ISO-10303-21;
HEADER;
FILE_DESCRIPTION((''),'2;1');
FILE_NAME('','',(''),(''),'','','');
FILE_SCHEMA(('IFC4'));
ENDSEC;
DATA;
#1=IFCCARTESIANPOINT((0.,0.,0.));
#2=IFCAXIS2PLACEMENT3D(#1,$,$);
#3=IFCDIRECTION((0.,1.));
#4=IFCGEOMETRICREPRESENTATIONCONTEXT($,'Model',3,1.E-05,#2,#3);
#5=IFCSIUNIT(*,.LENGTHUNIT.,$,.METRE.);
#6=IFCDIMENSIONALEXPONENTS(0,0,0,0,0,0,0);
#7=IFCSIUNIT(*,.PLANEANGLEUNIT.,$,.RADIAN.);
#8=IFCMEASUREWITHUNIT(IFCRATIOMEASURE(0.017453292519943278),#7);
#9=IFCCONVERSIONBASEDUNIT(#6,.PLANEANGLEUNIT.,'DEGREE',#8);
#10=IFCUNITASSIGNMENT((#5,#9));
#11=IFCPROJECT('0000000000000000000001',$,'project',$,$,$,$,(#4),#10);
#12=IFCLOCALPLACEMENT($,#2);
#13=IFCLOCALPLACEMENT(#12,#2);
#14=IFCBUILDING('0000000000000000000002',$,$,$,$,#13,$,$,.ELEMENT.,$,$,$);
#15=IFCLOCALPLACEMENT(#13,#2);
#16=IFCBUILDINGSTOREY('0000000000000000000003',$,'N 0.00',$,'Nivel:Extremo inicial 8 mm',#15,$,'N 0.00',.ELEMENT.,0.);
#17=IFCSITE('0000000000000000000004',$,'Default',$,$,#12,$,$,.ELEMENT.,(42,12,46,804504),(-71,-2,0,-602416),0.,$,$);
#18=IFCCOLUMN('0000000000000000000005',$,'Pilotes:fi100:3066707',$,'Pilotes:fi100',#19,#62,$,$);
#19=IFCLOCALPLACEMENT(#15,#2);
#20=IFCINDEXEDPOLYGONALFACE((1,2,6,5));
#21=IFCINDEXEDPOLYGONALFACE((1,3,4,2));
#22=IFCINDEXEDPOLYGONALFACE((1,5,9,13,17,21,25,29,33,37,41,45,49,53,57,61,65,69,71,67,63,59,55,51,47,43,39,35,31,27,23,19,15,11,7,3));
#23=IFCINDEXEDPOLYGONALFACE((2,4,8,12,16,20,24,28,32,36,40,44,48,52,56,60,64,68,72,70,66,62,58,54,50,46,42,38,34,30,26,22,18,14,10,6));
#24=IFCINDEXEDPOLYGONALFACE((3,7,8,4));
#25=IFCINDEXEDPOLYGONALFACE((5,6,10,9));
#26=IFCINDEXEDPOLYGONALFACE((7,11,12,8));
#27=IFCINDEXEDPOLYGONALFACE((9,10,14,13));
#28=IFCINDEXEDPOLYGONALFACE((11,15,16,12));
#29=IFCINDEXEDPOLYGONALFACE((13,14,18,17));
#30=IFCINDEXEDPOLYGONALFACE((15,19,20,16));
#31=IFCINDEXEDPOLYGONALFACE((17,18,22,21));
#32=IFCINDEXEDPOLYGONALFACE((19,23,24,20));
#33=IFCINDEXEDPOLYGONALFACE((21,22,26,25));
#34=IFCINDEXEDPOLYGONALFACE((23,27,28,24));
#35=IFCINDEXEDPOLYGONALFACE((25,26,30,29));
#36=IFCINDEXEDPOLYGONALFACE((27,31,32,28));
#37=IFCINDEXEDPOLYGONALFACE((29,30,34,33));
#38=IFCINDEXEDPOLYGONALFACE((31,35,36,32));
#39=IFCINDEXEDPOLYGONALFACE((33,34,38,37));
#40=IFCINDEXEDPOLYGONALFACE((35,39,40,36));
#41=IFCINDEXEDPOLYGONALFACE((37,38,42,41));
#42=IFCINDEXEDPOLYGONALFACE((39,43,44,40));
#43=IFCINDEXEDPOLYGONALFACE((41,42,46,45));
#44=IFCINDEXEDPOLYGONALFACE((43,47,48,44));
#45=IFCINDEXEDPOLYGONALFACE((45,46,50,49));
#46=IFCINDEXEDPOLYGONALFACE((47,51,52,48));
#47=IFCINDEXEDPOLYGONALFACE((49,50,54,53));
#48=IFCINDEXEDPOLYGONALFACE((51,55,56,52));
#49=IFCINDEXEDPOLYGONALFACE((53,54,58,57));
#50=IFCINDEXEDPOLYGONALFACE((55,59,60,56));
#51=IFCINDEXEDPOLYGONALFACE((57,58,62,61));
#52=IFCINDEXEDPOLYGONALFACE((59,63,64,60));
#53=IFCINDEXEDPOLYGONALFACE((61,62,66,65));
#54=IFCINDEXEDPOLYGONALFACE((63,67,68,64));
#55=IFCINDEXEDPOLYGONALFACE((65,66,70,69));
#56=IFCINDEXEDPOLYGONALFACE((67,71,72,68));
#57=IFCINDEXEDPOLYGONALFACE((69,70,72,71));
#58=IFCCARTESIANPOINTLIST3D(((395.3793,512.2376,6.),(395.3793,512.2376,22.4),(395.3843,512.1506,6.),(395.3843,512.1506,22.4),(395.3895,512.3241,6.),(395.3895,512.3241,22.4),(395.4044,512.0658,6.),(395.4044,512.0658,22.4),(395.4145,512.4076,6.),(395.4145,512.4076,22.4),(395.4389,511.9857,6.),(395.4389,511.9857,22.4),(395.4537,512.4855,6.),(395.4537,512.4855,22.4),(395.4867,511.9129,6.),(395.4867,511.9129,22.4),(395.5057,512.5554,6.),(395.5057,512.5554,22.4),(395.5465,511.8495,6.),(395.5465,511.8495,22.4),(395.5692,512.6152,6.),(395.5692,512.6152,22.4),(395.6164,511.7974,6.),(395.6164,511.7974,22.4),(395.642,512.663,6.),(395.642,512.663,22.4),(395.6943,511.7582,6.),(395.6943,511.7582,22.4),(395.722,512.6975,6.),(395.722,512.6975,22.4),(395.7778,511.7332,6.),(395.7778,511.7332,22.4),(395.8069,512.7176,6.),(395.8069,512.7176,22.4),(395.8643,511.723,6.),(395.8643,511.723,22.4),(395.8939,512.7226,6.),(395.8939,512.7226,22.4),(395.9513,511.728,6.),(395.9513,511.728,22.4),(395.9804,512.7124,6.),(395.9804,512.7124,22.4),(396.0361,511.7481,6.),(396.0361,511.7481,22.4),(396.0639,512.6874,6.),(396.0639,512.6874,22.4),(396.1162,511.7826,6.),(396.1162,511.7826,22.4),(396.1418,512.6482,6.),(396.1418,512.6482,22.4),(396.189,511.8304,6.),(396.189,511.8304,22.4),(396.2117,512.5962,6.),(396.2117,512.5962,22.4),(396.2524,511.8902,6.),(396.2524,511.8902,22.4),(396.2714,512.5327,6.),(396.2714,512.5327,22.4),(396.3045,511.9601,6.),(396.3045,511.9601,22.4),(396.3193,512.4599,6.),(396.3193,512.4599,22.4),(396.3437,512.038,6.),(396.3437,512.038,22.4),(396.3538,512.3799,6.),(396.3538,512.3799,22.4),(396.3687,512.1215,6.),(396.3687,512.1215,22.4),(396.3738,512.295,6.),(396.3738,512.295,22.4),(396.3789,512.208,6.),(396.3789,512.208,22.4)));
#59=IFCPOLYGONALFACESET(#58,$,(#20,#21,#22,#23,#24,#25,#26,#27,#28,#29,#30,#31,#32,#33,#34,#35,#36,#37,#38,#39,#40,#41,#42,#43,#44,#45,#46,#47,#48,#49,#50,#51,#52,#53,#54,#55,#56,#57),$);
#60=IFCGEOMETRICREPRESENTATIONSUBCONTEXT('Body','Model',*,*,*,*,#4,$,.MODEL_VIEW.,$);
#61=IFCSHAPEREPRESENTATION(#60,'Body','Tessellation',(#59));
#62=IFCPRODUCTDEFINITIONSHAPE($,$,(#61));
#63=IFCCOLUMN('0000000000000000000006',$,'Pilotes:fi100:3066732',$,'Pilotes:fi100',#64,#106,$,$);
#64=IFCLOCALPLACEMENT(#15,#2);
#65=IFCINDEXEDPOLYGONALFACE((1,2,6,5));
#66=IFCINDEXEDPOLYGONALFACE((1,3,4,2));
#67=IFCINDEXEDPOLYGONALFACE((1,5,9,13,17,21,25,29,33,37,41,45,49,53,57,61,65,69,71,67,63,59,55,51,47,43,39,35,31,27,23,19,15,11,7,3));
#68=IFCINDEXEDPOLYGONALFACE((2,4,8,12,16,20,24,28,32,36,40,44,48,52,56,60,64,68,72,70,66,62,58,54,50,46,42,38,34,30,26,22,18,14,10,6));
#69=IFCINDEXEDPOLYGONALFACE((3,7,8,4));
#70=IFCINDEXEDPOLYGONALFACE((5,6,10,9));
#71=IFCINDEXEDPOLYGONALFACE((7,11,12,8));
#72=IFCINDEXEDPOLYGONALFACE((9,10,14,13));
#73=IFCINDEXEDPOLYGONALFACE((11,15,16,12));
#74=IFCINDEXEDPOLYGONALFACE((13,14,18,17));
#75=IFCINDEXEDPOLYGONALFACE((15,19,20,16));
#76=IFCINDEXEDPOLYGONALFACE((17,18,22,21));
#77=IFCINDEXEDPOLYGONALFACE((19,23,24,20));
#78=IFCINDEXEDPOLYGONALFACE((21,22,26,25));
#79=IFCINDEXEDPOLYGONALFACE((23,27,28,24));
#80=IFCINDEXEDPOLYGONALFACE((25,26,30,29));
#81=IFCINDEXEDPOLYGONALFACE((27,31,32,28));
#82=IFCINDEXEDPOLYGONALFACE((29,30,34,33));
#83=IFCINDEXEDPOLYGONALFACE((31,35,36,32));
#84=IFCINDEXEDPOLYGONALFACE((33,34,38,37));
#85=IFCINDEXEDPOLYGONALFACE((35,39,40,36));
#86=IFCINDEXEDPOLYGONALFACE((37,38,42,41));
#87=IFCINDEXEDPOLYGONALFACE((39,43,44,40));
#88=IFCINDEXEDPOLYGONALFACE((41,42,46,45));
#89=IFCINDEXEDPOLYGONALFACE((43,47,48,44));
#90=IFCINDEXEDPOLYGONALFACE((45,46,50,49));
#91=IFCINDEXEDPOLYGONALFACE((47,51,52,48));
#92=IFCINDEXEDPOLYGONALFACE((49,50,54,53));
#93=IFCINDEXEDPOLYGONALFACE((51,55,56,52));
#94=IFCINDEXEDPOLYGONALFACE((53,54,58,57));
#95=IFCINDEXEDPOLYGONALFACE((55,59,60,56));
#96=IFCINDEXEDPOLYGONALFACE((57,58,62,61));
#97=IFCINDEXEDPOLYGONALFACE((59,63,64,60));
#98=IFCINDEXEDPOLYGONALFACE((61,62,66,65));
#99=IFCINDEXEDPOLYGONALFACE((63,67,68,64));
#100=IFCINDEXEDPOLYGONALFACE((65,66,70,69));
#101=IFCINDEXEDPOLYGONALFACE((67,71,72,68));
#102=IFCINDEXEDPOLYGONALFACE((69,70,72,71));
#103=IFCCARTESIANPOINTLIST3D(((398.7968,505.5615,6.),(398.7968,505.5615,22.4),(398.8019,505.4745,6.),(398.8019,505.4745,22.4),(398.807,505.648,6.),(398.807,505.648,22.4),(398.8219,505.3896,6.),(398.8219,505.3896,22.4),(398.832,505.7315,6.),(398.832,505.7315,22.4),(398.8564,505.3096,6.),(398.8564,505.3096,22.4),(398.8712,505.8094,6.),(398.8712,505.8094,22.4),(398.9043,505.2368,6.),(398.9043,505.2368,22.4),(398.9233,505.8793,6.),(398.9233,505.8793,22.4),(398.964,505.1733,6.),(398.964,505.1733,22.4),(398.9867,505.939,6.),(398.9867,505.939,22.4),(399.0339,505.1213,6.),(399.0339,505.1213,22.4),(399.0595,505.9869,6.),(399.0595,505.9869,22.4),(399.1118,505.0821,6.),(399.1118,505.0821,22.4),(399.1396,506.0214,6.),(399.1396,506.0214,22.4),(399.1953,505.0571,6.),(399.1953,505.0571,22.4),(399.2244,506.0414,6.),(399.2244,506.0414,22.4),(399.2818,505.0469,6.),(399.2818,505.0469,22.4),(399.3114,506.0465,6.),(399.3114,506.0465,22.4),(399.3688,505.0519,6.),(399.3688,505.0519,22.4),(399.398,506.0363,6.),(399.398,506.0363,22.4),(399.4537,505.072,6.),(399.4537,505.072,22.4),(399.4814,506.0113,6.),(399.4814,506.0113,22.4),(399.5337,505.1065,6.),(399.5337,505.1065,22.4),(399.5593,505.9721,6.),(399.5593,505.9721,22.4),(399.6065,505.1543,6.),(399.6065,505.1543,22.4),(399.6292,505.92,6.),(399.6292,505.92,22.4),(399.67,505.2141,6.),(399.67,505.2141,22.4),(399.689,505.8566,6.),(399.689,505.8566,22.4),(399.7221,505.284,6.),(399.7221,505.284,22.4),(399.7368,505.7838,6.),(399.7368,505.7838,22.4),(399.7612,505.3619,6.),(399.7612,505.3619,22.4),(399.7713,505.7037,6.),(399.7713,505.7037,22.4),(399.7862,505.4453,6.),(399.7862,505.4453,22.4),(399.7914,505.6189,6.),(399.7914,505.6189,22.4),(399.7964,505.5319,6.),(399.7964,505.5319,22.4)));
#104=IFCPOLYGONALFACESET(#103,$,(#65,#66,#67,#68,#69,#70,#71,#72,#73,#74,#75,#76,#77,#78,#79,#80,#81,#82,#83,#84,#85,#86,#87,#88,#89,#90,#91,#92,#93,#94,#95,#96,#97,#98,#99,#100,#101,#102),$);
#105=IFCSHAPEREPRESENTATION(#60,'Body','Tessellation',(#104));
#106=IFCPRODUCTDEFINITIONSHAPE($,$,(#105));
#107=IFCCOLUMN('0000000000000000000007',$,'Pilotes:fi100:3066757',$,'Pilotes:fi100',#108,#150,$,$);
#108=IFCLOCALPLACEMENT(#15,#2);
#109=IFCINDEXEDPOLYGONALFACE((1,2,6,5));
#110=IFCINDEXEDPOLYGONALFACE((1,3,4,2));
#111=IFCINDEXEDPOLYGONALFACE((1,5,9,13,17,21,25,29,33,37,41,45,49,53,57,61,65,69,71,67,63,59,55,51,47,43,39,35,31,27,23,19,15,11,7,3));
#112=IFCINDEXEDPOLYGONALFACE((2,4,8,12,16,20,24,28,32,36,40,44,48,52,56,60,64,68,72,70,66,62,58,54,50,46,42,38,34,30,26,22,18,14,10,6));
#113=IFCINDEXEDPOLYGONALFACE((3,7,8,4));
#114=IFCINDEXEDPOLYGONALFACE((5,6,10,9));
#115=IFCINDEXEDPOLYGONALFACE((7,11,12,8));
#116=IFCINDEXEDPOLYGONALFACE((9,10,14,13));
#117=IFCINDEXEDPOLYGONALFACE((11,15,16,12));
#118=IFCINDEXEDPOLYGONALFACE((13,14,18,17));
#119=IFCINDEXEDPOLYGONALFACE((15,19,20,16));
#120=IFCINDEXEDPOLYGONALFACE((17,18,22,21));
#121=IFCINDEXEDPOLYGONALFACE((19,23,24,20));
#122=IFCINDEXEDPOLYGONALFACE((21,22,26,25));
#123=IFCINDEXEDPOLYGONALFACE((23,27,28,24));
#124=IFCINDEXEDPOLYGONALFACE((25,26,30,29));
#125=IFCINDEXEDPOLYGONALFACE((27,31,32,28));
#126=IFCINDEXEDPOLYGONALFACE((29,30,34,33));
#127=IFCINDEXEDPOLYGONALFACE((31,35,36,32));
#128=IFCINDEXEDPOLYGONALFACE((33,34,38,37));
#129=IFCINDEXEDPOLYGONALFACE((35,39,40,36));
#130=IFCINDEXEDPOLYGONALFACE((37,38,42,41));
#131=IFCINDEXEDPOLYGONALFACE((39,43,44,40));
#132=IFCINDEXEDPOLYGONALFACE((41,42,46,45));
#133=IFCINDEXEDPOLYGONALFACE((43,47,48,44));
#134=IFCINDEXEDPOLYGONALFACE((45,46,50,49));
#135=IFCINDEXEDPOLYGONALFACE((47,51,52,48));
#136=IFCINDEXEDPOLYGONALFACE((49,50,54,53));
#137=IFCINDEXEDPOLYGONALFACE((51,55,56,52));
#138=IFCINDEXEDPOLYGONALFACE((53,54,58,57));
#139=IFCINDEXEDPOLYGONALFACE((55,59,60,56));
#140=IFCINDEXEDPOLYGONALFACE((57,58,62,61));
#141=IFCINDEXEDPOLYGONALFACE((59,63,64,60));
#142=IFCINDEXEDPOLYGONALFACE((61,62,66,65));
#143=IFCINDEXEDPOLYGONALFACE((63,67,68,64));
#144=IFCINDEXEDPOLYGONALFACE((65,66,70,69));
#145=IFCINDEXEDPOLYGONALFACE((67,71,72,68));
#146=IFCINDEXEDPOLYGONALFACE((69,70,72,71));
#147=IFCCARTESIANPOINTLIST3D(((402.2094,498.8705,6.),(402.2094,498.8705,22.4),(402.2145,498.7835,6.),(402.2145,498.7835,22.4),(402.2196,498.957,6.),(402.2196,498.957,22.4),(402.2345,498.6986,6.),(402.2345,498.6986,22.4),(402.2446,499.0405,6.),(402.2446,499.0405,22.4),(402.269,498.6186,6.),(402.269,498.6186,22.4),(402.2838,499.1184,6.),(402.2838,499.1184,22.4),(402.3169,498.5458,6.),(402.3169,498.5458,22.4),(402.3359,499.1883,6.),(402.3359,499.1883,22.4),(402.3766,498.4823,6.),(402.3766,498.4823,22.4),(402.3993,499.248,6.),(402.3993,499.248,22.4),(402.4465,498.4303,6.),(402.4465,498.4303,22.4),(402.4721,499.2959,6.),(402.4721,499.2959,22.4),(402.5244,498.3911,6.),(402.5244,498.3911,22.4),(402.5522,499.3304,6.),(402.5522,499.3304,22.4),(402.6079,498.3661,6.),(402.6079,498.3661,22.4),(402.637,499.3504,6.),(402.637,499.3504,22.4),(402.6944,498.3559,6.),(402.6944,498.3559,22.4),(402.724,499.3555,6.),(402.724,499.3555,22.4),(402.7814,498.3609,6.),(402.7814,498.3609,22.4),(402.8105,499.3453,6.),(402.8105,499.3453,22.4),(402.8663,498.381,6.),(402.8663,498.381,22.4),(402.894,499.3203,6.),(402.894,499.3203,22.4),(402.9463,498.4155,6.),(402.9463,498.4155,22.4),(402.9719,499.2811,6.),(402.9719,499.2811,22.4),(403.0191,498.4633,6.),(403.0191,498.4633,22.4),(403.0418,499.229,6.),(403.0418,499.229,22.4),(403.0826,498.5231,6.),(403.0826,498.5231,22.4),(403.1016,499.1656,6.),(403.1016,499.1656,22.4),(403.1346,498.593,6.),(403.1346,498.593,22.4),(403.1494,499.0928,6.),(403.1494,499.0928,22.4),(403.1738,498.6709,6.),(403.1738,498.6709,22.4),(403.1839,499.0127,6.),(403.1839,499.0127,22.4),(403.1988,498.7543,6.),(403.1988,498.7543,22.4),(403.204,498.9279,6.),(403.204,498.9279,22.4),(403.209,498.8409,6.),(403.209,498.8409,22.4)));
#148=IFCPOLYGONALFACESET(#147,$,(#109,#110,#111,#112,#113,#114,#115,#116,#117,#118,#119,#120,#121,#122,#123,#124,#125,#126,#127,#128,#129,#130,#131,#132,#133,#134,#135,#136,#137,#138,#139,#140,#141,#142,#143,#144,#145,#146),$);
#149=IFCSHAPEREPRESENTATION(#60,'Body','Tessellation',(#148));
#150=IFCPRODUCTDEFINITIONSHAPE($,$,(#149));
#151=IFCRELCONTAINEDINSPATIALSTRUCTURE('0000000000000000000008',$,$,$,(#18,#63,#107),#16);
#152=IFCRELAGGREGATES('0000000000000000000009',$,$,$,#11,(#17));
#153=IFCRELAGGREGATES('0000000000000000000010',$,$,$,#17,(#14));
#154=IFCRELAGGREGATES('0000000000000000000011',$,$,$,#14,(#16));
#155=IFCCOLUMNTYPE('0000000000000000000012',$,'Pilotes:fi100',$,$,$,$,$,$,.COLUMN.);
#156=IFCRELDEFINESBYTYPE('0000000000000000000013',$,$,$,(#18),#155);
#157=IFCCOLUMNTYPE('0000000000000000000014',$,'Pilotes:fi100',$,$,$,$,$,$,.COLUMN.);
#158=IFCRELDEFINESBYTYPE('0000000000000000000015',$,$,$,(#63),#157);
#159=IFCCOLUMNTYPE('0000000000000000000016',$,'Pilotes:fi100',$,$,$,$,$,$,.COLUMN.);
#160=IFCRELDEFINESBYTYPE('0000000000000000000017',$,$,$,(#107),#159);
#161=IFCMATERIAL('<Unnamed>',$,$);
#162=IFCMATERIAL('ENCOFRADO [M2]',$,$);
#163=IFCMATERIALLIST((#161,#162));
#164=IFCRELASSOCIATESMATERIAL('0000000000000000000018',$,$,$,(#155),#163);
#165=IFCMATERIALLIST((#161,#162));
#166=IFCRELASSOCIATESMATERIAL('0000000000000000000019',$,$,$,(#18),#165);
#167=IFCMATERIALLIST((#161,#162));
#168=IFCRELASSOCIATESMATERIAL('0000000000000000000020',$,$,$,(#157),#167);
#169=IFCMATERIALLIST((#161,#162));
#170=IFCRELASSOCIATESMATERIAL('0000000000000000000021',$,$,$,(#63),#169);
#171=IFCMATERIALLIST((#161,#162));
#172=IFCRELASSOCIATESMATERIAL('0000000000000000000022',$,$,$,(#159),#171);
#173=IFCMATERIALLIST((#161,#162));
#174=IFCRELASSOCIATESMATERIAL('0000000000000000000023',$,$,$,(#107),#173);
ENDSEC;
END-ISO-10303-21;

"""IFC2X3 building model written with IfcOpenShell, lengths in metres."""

from ifc_helpers import new_model, entity, si_unit, converted_unit, direction, frame, frame_2d, origin, place, context, subcontext, project, spatial, circle, extrude, source, transform, mapped, material, material_list, type_object, type_shapes, element, save


model = new_model("IFC2X3")

# Units and contexts
model_context = context("Model", 3, precision=1e-05, world=origin(), true_north=direction((0.0, 1.0)))
body_context = subcontext(model_context, "Body", "Model", "MODEL_VIEW")
ifc_project = project(units=[si_unit("LENGTHUNIT", "METRE"), converted_unit("PLANEANGLEUNIT", "DEGREE", entity("IfcRatioMeasure", 0.017453292519943278), si_unit("PLANEANGLEUNIT", "RADIAN"), dimensions=[0, 0, 0, 0, 0, 0, 0])], contexts=[model_context])

# Site, building, storey
site_placement = place(None, origin())
site = spatial("IfcSite", under=ifc_project, at=site_placement, Name="Default", CompositionType="ELEMENT", RefLatitude=(42, 12, 46, 804504), RefLongitude=(-71, -2, 0, -602416), RefElevation=0.0)
building_placement = place(site_placement, origin())
building = spatial("IfcBuilding", under=site, at=building_placement, CompositionType="ELEMENT")
storey_placement = place(building_placement, origin())
storey = spatial("IfcBuildingStorey", under=building, at=storey_placement, Name="N 0.00", ObjectType="Nivel:Extremo inicial 8 mm", LongName="N 0.00", CompositionType="ELEMENT", Elevation=0.0)

# Columns
ifc_material_1 = material(Name="<Unnamed>")
ifc_material_2 = material(Name="ENCOFRADO [M2]")
ifc_material_list_1 = material_list([ifc_material_1, ifc_material_2])
ifc_material_list_2 = material_list([ifc_material_1, ifc_material_2])
column_type_1 = type_object("IfcColumnType", Name="Pilotes:fi100", PredefinedType="COLUMN", material=ifc_material_list_2)
shared_shape_1 = source(origin(), body_context, "Body", "SweptSolid", [
    extrude(circle(Radius=0.5, at=frame_2d((0.0, 0.1667), x_axis=(1.0, 0.0))), frame((395.884, 512.3894, 6.0), z_axis=(0.0, 0.0, 1.0), x_axis=(-0.999563, 0.029559, 0.0)), (0.0, 0.0, 1.0), 16.4),
])
type_shapes(column_type_1, [shared_shape_1])
column_1_placement = place(storey_placement, origin())
element("IfcColumn", 1, at=column_1_placement, inside=storey, type_object=column_type_1, material=ifc_material_list_1, Name="Pilotes:fi100:3066707", ObjectType="Pilotes:fi100", context=body_context, shape_type="MappedRepresentation", body=[
    mapped(shared_shape_1, transform((0.0, 0.0, 0.0), scale=1.0)),
])
ifc_material_list_3 = material_list([ifc_material_1, ifc_material_2])
ifc_material_list_4 = material_list([ifc_material_1, ifc_material_2])
column_type_2 = type_object("IfcColumnType", Name="Pilotes:fi100", PredefinedType="COLUMN", material=ifc_material_list_4)
shared_shape_2 = source(origin(), body_context, "Body", "SweptSolid", [
    extrude(circle(Radius=0.5, at=frame_2d((0.0, 0.1667), x_axis=(1.0, 0.0))), frame((399.3015, 505.7133, 6.0), z_axis=(0.0, 0.0, 1.0), x_axis=(-0.999563, 0.029559, 0.0)), (0.0, 0.0, 1.0), 16.4),
])
type_shapes(column_type_2, [shared_shape_2])
column_2_placement = place(storey_placement, origin())
element("IfcColumn", 2, at=column_2_placement, inside=storey, type_object=column_type_2, material=ifc_material_list_3, Name="Pilotes:fi100:3066732", ObjectType="Pilotes:fi100", context=body_context, shape_type="MappedRepresentation", body=[
    mapped(shared_shape_2, transform((0.0, 0.0, 0.0), scale=1.0)),
])
ifc_material_list_5 = material_list([ifc_material_1, ifc_material_2])
ifc_material_list_6 = material_list([ifc_material_1, ifc_material_2])
column_type_3 = type_object("IfcColumnType", Name="Pilotes:fi100", PredefinedType="COLUMN", material=ifc_material_list_6)
shared_shape_3 = source(origin(), body_context, "Body", "SweptSolid", [
    extrude(circle(Radius=0.5, at=frame_2d((0.0, 0.1667), x_axis=(1.0, 0.0))), frame((402.7141, 499.0223, 6.0), z_axis=(0.0, 0.0, 1.0), x_axis=(-0.999563, 0.029559, 0.0)), (0.0, 0.0, 1.0), 16.4),
])
type_shapes(column_type_3, [shared_shape_3])
column_3_placement = place(storey_placement, origin())
element("IfcColumn", 3, at=column_3_placement, inside=storey, type_object=column_type_3, material=ifc_material_list_5, Name="Pilotes:fi100:3066757", ObjectType="Pilotes:fi100", context=body_context, shape_type="MappedRepresentation", body=[
    mapped(shared_shape_3, transform((0.0, 0.0, 0.0), scale=1.0)),
])

save(model, "model.ifc")
